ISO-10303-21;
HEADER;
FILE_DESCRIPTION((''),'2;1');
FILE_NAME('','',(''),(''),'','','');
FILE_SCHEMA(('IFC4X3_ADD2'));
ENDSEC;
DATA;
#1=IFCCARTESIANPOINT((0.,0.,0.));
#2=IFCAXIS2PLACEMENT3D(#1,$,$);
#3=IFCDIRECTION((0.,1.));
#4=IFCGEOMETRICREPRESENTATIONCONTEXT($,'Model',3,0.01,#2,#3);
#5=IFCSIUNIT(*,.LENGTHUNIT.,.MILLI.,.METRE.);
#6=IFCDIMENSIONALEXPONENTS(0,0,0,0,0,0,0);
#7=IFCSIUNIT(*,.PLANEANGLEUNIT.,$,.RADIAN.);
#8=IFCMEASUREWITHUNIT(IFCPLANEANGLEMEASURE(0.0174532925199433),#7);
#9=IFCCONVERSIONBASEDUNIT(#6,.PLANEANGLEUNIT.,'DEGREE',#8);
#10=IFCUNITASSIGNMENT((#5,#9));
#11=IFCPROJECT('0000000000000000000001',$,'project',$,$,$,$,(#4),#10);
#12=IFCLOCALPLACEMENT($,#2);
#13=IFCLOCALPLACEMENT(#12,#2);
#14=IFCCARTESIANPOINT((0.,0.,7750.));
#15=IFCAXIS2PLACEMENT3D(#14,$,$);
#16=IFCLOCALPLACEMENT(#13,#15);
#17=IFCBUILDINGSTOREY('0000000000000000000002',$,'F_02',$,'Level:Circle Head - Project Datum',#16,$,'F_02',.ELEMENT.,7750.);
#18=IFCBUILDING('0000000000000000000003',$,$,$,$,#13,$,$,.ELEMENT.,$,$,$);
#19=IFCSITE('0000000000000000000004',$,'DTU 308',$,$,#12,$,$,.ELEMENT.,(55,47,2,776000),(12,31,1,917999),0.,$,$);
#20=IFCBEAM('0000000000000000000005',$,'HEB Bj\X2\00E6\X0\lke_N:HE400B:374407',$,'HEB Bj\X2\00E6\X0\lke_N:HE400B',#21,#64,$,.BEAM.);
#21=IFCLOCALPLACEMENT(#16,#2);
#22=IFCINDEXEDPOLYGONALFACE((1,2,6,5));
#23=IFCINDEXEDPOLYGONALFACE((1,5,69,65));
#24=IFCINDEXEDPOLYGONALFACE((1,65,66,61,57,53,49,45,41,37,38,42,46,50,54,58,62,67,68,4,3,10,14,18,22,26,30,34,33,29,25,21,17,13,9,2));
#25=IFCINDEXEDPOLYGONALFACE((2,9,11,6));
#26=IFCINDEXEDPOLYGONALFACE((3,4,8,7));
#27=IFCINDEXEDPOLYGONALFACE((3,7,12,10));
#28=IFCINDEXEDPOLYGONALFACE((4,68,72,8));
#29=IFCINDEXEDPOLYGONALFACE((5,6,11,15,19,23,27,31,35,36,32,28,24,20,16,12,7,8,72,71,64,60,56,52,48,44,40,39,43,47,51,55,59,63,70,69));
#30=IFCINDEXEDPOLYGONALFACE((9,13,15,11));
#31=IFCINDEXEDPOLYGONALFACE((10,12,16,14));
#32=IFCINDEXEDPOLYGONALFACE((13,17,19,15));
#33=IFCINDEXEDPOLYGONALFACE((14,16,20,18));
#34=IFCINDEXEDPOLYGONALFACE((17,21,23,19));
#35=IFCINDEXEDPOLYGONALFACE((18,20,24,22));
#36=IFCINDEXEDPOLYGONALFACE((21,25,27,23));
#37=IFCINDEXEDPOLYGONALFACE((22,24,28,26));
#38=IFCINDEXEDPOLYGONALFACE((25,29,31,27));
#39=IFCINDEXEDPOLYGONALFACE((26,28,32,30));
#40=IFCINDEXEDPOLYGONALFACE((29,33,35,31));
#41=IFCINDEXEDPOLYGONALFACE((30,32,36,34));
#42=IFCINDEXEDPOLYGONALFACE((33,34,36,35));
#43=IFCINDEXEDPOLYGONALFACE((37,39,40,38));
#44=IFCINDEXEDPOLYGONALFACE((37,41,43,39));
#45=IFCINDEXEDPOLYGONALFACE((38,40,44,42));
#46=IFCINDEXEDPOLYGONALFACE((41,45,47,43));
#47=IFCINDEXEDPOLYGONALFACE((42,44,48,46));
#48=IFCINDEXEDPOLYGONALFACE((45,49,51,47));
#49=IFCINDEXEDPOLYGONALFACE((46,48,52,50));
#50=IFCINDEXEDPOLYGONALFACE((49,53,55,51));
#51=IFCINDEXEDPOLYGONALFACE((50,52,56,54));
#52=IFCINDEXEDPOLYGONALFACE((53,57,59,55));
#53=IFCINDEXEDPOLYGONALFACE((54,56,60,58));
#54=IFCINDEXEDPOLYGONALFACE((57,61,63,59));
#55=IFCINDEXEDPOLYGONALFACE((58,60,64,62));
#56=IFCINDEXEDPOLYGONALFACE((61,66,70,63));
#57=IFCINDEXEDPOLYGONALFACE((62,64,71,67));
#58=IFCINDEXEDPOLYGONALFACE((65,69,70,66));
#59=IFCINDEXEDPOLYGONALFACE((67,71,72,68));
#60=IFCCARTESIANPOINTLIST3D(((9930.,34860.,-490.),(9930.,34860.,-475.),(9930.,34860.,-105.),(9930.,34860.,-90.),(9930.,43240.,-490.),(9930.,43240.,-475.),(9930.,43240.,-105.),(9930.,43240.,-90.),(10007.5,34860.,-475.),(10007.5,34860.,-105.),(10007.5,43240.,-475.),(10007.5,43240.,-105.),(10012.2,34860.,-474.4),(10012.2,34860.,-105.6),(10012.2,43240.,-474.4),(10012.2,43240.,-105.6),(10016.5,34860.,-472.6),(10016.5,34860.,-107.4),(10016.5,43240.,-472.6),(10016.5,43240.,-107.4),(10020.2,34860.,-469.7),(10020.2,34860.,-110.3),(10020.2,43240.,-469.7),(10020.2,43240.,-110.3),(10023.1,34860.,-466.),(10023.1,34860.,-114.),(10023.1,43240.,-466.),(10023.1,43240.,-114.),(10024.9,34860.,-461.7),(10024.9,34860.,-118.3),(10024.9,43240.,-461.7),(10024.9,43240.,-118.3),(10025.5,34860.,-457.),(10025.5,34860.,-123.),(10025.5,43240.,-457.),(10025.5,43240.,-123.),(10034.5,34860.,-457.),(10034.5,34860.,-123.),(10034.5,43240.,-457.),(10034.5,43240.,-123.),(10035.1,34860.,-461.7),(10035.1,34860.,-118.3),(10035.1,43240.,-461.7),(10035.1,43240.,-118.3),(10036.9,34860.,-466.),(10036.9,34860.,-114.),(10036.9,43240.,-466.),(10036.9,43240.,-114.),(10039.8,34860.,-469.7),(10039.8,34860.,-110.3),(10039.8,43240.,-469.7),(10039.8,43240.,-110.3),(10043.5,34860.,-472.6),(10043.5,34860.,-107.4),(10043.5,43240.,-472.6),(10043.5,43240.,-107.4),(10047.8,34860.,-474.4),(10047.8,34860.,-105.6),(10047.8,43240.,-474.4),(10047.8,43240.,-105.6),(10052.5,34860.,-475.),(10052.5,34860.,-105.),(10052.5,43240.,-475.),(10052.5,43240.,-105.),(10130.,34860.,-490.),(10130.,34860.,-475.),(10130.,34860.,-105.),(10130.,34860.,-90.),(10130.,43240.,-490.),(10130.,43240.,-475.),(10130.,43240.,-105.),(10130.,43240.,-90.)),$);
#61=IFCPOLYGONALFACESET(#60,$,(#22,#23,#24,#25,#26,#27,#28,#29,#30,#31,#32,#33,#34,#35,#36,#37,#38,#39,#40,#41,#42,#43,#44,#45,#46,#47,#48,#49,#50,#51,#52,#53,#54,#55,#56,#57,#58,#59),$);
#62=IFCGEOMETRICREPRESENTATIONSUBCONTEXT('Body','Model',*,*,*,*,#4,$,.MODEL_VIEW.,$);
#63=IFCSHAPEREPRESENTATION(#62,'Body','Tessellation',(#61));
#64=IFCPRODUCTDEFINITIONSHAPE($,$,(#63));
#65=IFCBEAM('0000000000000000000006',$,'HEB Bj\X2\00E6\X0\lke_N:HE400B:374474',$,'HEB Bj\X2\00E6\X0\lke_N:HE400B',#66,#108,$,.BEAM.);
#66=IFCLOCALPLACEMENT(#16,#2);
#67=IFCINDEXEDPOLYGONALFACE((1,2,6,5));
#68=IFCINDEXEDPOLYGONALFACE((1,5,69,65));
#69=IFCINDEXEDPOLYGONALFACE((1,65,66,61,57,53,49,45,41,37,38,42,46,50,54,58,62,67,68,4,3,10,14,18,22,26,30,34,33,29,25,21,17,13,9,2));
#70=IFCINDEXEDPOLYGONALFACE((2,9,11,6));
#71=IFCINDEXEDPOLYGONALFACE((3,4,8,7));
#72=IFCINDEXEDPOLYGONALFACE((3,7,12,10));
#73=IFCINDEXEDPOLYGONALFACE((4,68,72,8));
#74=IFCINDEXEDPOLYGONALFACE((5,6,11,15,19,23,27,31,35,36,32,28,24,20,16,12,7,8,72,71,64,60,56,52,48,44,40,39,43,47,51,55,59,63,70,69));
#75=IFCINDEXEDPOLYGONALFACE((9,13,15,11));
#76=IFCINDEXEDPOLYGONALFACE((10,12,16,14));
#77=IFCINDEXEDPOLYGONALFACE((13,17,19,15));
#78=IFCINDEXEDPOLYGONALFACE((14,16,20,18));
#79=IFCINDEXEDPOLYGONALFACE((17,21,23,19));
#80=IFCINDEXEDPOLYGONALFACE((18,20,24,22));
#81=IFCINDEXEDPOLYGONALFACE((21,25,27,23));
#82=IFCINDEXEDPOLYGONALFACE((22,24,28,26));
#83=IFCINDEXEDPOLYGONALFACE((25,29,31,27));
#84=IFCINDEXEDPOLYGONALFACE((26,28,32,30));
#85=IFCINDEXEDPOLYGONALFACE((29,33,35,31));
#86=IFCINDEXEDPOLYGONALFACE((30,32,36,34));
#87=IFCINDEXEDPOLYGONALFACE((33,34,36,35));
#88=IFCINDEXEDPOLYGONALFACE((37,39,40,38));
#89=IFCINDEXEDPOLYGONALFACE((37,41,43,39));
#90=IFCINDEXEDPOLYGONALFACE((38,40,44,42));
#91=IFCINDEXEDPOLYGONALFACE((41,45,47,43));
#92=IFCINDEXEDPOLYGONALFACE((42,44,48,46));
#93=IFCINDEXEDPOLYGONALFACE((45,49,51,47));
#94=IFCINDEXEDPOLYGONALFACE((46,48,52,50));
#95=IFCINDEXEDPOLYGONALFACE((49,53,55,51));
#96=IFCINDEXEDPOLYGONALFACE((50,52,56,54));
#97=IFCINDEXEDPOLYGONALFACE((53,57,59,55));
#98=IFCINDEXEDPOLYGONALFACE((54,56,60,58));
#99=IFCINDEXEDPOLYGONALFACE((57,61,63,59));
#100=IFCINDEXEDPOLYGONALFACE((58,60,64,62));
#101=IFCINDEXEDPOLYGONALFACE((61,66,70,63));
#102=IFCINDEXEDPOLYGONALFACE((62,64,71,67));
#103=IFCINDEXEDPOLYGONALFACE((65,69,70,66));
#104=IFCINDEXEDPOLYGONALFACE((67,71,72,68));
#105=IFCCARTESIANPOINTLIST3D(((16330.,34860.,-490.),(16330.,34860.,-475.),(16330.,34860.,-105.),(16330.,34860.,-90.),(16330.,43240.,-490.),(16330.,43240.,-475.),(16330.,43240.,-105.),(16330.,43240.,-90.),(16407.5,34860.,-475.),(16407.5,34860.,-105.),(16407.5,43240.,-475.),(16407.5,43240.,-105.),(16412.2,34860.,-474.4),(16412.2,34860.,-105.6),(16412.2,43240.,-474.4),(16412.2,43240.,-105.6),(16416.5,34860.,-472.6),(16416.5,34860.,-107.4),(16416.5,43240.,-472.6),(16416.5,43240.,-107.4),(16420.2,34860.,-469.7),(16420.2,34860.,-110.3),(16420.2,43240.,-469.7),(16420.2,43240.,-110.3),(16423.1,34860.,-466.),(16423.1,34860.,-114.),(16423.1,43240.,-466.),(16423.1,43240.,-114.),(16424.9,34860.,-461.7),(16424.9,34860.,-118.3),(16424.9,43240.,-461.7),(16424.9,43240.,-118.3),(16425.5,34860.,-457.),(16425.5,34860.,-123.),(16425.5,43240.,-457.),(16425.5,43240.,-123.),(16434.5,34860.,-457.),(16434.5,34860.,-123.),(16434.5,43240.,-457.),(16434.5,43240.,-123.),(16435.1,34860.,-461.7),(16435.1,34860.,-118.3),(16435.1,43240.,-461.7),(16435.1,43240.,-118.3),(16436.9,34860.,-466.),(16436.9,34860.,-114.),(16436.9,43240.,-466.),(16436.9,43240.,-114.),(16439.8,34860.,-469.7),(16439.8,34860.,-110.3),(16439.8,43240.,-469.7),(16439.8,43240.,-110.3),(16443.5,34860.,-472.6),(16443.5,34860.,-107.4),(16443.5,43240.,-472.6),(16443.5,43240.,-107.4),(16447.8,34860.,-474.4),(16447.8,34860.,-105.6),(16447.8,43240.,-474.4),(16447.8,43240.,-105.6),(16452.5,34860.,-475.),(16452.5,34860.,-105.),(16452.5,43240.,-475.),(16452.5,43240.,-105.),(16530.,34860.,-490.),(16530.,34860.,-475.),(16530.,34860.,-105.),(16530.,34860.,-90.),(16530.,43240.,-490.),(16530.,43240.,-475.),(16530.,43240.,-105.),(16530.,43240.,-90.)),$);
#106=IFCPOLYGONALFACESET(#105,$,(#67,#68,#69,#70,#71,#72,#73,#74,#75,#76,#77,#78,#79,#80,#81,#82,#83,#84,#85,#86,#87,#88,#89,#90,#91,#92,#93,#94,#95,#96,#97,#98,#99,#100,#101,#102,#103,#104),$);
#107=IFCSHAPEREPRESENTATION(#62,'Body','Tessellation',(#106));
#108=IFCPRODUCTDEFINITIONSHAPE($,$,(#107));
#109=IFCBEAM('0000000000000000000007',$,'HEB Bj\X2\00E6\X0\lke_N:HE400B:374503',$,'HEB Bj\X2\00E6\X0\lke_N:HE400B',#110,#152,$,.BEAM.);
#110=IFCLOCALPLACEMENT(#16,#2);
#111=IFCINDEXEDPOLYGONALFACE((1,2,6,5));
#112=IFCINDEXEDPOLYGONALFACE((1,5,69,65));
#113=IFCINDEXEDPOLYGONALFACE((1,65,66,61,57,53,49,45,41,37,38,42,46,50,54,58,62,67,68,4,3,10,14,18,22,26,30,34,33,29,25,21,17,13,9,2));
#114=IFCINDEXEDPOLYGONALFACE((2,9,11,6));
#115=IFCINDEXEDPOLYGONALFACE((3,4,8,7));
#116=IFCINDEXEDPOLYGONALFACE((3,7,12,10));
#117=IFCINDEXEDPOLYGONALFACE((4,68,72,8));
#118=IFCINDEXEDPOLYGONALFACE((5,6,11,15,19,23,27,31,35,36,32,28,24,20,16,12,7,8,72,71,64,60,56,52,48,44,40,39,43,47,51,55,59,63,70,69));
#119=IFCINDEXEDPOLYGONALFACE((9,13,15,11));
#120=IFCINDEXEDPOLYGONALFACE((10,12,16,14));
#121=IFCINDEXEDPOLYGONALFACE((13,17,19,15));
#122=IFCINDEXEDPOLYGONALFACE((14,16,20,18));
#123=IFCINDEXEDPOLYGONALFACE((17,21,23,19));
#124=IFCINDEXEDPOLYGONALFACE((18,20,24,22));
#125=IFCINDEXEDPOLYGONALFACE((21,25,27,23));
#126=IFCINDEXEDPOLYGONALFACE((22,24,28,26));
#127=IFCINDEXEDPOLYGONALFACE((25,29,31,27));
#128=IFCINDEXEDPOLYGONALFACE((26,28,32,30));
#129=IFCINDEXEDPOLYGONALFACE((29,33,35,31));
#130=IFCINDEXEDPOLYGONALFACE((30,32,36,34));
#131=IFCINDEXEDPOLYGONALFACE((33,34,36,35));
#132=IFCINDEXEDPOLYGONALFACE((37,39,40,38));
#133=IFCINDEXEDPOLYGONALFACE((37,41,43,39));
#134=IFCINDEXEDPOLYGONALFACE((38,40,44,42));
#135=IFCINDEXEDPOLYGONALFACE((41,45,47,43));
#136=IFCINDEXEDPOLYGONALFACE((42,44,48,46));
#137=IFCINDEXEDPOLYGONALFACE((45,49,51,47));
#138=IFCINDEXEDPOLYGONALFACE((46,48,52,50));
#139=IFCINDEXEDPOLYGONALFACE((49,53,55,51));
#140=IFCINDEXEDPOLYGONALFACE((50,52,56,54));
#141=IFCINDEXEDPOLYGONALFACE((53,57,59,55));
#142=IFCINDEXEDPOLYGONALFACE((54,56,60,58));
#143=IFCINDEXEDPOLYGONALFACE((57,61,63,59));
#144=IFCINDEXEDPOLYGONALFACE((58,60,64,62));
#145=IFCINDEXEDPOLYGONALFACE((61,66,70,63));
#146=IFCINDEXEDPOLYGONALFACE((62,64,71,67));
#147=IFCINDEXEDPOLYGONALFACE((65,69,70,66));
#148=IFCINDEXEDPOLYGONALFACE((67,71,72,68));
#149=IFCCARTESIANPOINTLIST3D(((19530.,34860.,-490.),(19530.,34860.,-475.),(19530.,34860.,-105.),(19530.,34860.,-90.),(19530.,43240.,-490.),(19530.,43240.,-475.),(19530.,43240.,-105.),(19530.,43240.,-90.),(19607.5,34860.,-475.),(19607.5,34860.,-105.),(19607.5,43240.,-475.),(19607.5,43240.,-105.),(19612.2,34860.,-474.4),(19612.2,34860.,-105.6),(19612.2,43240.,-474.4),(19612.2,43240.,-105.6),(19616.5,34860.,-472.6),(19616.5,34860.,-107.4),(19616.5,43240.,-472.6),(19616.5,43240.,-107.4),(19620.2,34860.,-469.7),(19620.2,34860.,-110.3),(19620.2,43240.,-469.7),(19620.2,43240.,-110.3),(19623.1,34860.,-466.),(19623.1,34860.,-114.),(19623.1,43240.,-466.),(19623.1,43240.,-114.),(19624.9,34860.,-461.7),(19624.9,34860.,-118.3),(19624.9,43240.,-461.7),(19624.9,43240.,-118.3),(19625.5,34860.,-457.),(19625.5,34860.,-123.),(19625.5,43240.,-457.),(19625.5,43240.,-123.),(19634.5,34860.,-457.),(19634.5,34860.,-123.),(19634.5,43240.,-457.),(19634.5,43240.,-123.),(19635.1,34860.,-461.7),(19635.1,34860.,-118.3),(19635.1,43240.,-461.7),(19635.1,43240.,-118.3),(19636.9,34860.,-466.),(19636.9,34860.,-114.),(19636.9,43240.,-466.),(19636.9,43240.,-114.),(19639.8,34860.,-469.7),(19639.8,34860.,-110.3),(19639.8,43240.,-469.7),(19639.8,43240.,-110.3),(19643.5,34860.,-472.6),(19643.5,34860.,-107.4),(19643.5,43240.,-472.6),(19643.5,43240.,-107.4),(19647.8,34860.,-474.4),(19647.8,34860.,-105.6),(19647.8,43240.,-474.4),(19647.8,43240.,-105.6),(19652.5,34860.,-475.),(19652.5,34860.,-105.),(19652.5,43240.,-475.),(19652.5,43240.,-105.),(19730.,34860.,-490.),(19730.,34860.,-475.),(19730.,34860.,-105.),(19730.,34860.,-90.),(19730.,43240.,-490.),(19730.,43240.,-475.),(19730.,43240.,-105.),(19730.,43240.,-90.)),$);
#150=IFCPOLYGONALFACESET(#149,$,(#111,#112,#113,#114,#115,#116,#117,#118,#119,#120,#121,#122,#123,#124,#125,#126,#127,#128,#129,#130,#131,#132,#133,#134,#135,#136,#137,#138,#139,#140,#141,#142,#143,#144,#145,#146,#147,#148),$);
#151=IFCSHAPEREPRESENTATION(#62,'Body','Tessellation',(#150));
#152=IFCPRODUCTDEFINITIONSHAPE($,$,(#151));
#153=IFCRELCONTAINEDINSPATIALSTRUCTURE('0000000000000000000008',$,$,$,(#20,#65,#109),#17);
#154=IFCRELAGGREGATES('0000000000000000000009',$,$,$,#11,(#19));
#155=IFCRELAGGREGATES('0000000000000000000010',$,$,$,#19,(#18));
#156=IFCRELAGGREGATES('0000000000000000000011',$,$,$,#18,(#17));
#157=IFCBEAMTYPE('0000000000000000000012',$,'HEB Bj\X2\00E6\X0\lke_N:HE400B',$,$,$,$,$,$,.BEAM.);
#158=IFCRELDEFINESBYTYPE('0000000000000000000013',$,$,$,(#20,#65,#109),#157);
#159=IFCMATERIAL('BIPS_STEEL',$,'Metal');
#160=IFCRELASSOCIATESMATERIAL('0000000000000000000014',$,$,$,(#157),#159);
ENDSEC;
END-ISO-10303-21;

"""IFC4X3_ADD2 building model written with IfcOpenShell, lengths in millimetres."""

from ifc_helpers import new_model, entity, si_unit, converted_unit, direction, frame, frame_2d, origin, place, context, subcontext, project, spatial, polyline, circle_curve, parameter, trimmed, segment, composite_curve, outline, extrude, source, transform, mapped, material, material_profile, profile_set, type_object, element, save


model = new_model("IFC4X3_ADD2")

# Units and contexts
model_context = context("Model", 3, precision=0.01, world=origin(), true_north=direction((0.0, 1.0)))
body_context = subcontext(model_context, "Body", "Model", "MODEL_VIEW")
ifc_project = project(units=[si_unit("LENGTHUNIT", "METRE", prefix="MILLI"), converted_unit("PLANEANGLEUNIT", "DEGREE", entity("IfcPlaneAngleMeasure", 0.0174532925199433), si_unit("PLANEANGLEUNIT", "RADIAN"), dimensions=[0, 0, 0, 0, 0, 0, 0])], contexts=[model_context])

# Site, building, storey
site_placement = place(None, origin())
site = spatial("IfcSite", under=ifc_project, at=site_placement, Name="DTU 308", CompositionType="ELEMENT", RefLatitude=(55, 47, 2, 776000), RefLongitude=(12, 31, 1, 917999), RefElevation=0.0)
building_placement = place(site_placement, origin())
building = spatial("IfcBuilding", under=site, at=building_placement, CompositionType="ELEMENT")
storey_placement = place(building_placement, frame((0.0, 0.0, 7750.0)))
storey = spatial("IfcBuildingStorey", under=building, at=storey_placement, Name="F_02", ObjectType="Level:Circle Head - Project Datum", LongName="F_02", CompositionType="ELEMENT", Elevation=7750.0)

# Shared definitions
ifc_material = material(Name="BIPS_STEEL", Category="Metal")

# Beams
ifc_material_profile_1 = material_profile(ifc_material, outline(composite_curve([segment(polyline([(-100.0, -185.0), (-100.0, -200.0)]), True, "CONTINUOUS"), segment(polyline([(-100.0, -200.0), (100.0, -200.0)]), True, "CONTINUOUS"), segment(polyline([(100.0, -200.0), (100.0, -185.0)]), True, "CONTINUOUS"), segment(polyline([(100.0, -185.0), (22.5, -185.0)]), True, "CONTINUOUS"), segment(trimmed(circle_curve(frame_2d((22.5, -167.0), x_axis=(1.0, 0.0)), 18.0), [parameter(180.0)], [parameter(270.0)], True, "PARAMETER"), False, "CONTINUOUS"), segment(polyline([(4.5, -167.0), (4.5, 167.0)]), True, "CONTINUOUS"), segment(trimmed(circle_curve(frame_2d((22.5, 167.0), x_axis=(1.0, 0.0)), 18.0), [parameter(90.0)], [parameter(180.0)], True, "PARAMETER"), False, "CONTINUOUS"), segment(polyline([(22.5, 185.0), (100.0, 185.0)]), True, "CONTINUOUS"), segment(polyline([(100.0, 185.0), (100.0, 200.0)]), True, "CONTINUOUS"), segment(polyline([(100.0, 200.0), (-100.0, 200.0)]), True, "CONTINUOUS"), segment(polyline([(-100.0, 200.0), (-100.0, 185.0)]), True, "CONTINUOUS"), segment(polyline([(-100.0, 185.0), (-22.5, 185.0)]), True, "CONTINUOUS"), segment(trimmed(circle_curve(frame_2d((-22.5, 167.0), x_axis=(1.0, 0.0)), 18.0), [parameter(360.0)], [parameter(90.0)], True, "PARAMETER"), False, "CONTINUOUS"), segment(polyline([(-4.5, 167.0), (-4.5, -167.0)]), True, "CONTINUOUS"), segment(trimmed(circle_curve(frame_2d((-22.5, -167.0), x_axis=(1.0, 0.0)), 18.0), [parameter(270.0)], [parameter(360.0)], True, "PARAMETER"), False, "CONTINUOUS"), segment(polyline([(-22.5, -185.0), (-100.0, -185.0)]), True, "CONTINUOUS")], self_intersect=False)), Name="HE400B")
ifc_profile_set_1 = profile_set([ifc_material_profile_1], Name="HE400B")
beam_type_1 = type_object("IfcBeamType", Name="HEB Bjælke_N:HE400B", PredefinedType="BEAM", material=ifc_profile_set_1)
shared_shape_1 = source(origin(), body_context, "Body", "SweptSolid", [
    extrude(outline(composite_curve([segment(polyline([(-100.0, -185.0), (-100.0, -200.0)]), True, "CONTINUOUS"), segment(polyline([(-100.0, -200.0), (100.0, -200.0)]), True, "CONTINUOUS"), segment(polyline([(100.0, -200.0), (100.0, -185.0)]), True, "CONTINUOUS"), segment(polyline([(100.0, -185.0), (22.5, -185.0)]), True, "CONTINUOUS"), segment(trimmed(circle_curve(frame_2d((22.5, -167.0), x_axis=(1.0, 0.0)), 18.0), [parameter(180.0)], [parameter(270.0)], True, "PARAMETER"), False, "CONTINUOUS"), segment(polyline([(4.5, -167.0), (4.5, 167.0)]), True, "CONTINUOUS"), segment(trimmed(circle_curve(frame_2d((22.5, 167.0), x_axis=(1.0, 0.0)), 18.0), [parameter(90.0)], [parameter(180.0)], True, "PARAMETER"), False, "CONTINUOUS"), segment(polyline([(22.5, 185.0), (100.0, 185.0)]), True, "CONTINUOUS"), segment(polyline([(100.0, 185.0), (100.0, 200.0)]), True, "CONTINUOUS"), segment(polyline([(100.0, 200.0), (-100.0, 200.0)]), True, "CONTINUOUS"), segment(polyline([(-100.0, 200.0), (-100.0, 185.0)]), True, "CONTINUOUS"), segment(polyline([(-100.0, 185.0), (-22.5, 185.0)]), True, "CONTINUOUS"), segment(trimmed(circle_curve(frame_2d((-22.5, 167.0), x_axis=(1.0, 0.0)), 18.0), [parameter(360.0)], [parameter(90.0)], True, "PARAMETER"), False, "CONTINUOUS"), segment(polyline([(-4.5, 167.0), (-4.5, -167.0)]), True, "CONTINUOUS"), segment(trimmed(circle_curve(frame_2d((-22.5, -167.0), x_axis=(1.0, 0.0)), 18.0), [parameter(270.0)], [parameter(360.0)], True, "PARAMETER"), False, "CONTINUOUS"), segment(polyline([(-22.5, -185.0), (-100.0, -185.0)]), True, "CONTINUOUS")], self_intersect=False)), frame((-5880.0, 0.0, 0.0), z_axis=(-1.0, 0.0, 0.0), x_axis=(0.0, -1.0, 0.0)), (0.0, 0.0, -1.0), 8380.0),
])
for number, where, z_axis, x_axis, name in (
    (1, (10030.0, 37360.0, -290.0), (0.0, 0.0, 1.0), (0.0, -1.0, 0.0), "HEB Bjælke_N:HE400B:374407"),
    (2, (16430.0, 37360.0, -290.0), (0.0, 0.0, 1.0), (0.0, -1.0, 0.0), "HEB Bjælke_N:HE400B:374474"),
    (3, (19630.0, 37360.0, -290.0), (0.0, 0.0, 1.0), (0.0, -1.0, 0.0), "HEB Bjælke_N:HE400B:374503"),
):
    element("IfcBeam", number, at=place(storey_placement, frame(where, z_axis=z_axis, x_axis=x_axis)), inside=storey, type_object=beam_type_1, Name=name, ObjectType="HEB Bjælke_N:HE400B", PredefinedType="BEAM", context=body_context, shape_type="MappedRepresentation", body=[
        mapped(shared_shape_1, transform((0.0, 0.0, 0.0), scale=1.0)),
    ])

save(model, "model.ifc")
